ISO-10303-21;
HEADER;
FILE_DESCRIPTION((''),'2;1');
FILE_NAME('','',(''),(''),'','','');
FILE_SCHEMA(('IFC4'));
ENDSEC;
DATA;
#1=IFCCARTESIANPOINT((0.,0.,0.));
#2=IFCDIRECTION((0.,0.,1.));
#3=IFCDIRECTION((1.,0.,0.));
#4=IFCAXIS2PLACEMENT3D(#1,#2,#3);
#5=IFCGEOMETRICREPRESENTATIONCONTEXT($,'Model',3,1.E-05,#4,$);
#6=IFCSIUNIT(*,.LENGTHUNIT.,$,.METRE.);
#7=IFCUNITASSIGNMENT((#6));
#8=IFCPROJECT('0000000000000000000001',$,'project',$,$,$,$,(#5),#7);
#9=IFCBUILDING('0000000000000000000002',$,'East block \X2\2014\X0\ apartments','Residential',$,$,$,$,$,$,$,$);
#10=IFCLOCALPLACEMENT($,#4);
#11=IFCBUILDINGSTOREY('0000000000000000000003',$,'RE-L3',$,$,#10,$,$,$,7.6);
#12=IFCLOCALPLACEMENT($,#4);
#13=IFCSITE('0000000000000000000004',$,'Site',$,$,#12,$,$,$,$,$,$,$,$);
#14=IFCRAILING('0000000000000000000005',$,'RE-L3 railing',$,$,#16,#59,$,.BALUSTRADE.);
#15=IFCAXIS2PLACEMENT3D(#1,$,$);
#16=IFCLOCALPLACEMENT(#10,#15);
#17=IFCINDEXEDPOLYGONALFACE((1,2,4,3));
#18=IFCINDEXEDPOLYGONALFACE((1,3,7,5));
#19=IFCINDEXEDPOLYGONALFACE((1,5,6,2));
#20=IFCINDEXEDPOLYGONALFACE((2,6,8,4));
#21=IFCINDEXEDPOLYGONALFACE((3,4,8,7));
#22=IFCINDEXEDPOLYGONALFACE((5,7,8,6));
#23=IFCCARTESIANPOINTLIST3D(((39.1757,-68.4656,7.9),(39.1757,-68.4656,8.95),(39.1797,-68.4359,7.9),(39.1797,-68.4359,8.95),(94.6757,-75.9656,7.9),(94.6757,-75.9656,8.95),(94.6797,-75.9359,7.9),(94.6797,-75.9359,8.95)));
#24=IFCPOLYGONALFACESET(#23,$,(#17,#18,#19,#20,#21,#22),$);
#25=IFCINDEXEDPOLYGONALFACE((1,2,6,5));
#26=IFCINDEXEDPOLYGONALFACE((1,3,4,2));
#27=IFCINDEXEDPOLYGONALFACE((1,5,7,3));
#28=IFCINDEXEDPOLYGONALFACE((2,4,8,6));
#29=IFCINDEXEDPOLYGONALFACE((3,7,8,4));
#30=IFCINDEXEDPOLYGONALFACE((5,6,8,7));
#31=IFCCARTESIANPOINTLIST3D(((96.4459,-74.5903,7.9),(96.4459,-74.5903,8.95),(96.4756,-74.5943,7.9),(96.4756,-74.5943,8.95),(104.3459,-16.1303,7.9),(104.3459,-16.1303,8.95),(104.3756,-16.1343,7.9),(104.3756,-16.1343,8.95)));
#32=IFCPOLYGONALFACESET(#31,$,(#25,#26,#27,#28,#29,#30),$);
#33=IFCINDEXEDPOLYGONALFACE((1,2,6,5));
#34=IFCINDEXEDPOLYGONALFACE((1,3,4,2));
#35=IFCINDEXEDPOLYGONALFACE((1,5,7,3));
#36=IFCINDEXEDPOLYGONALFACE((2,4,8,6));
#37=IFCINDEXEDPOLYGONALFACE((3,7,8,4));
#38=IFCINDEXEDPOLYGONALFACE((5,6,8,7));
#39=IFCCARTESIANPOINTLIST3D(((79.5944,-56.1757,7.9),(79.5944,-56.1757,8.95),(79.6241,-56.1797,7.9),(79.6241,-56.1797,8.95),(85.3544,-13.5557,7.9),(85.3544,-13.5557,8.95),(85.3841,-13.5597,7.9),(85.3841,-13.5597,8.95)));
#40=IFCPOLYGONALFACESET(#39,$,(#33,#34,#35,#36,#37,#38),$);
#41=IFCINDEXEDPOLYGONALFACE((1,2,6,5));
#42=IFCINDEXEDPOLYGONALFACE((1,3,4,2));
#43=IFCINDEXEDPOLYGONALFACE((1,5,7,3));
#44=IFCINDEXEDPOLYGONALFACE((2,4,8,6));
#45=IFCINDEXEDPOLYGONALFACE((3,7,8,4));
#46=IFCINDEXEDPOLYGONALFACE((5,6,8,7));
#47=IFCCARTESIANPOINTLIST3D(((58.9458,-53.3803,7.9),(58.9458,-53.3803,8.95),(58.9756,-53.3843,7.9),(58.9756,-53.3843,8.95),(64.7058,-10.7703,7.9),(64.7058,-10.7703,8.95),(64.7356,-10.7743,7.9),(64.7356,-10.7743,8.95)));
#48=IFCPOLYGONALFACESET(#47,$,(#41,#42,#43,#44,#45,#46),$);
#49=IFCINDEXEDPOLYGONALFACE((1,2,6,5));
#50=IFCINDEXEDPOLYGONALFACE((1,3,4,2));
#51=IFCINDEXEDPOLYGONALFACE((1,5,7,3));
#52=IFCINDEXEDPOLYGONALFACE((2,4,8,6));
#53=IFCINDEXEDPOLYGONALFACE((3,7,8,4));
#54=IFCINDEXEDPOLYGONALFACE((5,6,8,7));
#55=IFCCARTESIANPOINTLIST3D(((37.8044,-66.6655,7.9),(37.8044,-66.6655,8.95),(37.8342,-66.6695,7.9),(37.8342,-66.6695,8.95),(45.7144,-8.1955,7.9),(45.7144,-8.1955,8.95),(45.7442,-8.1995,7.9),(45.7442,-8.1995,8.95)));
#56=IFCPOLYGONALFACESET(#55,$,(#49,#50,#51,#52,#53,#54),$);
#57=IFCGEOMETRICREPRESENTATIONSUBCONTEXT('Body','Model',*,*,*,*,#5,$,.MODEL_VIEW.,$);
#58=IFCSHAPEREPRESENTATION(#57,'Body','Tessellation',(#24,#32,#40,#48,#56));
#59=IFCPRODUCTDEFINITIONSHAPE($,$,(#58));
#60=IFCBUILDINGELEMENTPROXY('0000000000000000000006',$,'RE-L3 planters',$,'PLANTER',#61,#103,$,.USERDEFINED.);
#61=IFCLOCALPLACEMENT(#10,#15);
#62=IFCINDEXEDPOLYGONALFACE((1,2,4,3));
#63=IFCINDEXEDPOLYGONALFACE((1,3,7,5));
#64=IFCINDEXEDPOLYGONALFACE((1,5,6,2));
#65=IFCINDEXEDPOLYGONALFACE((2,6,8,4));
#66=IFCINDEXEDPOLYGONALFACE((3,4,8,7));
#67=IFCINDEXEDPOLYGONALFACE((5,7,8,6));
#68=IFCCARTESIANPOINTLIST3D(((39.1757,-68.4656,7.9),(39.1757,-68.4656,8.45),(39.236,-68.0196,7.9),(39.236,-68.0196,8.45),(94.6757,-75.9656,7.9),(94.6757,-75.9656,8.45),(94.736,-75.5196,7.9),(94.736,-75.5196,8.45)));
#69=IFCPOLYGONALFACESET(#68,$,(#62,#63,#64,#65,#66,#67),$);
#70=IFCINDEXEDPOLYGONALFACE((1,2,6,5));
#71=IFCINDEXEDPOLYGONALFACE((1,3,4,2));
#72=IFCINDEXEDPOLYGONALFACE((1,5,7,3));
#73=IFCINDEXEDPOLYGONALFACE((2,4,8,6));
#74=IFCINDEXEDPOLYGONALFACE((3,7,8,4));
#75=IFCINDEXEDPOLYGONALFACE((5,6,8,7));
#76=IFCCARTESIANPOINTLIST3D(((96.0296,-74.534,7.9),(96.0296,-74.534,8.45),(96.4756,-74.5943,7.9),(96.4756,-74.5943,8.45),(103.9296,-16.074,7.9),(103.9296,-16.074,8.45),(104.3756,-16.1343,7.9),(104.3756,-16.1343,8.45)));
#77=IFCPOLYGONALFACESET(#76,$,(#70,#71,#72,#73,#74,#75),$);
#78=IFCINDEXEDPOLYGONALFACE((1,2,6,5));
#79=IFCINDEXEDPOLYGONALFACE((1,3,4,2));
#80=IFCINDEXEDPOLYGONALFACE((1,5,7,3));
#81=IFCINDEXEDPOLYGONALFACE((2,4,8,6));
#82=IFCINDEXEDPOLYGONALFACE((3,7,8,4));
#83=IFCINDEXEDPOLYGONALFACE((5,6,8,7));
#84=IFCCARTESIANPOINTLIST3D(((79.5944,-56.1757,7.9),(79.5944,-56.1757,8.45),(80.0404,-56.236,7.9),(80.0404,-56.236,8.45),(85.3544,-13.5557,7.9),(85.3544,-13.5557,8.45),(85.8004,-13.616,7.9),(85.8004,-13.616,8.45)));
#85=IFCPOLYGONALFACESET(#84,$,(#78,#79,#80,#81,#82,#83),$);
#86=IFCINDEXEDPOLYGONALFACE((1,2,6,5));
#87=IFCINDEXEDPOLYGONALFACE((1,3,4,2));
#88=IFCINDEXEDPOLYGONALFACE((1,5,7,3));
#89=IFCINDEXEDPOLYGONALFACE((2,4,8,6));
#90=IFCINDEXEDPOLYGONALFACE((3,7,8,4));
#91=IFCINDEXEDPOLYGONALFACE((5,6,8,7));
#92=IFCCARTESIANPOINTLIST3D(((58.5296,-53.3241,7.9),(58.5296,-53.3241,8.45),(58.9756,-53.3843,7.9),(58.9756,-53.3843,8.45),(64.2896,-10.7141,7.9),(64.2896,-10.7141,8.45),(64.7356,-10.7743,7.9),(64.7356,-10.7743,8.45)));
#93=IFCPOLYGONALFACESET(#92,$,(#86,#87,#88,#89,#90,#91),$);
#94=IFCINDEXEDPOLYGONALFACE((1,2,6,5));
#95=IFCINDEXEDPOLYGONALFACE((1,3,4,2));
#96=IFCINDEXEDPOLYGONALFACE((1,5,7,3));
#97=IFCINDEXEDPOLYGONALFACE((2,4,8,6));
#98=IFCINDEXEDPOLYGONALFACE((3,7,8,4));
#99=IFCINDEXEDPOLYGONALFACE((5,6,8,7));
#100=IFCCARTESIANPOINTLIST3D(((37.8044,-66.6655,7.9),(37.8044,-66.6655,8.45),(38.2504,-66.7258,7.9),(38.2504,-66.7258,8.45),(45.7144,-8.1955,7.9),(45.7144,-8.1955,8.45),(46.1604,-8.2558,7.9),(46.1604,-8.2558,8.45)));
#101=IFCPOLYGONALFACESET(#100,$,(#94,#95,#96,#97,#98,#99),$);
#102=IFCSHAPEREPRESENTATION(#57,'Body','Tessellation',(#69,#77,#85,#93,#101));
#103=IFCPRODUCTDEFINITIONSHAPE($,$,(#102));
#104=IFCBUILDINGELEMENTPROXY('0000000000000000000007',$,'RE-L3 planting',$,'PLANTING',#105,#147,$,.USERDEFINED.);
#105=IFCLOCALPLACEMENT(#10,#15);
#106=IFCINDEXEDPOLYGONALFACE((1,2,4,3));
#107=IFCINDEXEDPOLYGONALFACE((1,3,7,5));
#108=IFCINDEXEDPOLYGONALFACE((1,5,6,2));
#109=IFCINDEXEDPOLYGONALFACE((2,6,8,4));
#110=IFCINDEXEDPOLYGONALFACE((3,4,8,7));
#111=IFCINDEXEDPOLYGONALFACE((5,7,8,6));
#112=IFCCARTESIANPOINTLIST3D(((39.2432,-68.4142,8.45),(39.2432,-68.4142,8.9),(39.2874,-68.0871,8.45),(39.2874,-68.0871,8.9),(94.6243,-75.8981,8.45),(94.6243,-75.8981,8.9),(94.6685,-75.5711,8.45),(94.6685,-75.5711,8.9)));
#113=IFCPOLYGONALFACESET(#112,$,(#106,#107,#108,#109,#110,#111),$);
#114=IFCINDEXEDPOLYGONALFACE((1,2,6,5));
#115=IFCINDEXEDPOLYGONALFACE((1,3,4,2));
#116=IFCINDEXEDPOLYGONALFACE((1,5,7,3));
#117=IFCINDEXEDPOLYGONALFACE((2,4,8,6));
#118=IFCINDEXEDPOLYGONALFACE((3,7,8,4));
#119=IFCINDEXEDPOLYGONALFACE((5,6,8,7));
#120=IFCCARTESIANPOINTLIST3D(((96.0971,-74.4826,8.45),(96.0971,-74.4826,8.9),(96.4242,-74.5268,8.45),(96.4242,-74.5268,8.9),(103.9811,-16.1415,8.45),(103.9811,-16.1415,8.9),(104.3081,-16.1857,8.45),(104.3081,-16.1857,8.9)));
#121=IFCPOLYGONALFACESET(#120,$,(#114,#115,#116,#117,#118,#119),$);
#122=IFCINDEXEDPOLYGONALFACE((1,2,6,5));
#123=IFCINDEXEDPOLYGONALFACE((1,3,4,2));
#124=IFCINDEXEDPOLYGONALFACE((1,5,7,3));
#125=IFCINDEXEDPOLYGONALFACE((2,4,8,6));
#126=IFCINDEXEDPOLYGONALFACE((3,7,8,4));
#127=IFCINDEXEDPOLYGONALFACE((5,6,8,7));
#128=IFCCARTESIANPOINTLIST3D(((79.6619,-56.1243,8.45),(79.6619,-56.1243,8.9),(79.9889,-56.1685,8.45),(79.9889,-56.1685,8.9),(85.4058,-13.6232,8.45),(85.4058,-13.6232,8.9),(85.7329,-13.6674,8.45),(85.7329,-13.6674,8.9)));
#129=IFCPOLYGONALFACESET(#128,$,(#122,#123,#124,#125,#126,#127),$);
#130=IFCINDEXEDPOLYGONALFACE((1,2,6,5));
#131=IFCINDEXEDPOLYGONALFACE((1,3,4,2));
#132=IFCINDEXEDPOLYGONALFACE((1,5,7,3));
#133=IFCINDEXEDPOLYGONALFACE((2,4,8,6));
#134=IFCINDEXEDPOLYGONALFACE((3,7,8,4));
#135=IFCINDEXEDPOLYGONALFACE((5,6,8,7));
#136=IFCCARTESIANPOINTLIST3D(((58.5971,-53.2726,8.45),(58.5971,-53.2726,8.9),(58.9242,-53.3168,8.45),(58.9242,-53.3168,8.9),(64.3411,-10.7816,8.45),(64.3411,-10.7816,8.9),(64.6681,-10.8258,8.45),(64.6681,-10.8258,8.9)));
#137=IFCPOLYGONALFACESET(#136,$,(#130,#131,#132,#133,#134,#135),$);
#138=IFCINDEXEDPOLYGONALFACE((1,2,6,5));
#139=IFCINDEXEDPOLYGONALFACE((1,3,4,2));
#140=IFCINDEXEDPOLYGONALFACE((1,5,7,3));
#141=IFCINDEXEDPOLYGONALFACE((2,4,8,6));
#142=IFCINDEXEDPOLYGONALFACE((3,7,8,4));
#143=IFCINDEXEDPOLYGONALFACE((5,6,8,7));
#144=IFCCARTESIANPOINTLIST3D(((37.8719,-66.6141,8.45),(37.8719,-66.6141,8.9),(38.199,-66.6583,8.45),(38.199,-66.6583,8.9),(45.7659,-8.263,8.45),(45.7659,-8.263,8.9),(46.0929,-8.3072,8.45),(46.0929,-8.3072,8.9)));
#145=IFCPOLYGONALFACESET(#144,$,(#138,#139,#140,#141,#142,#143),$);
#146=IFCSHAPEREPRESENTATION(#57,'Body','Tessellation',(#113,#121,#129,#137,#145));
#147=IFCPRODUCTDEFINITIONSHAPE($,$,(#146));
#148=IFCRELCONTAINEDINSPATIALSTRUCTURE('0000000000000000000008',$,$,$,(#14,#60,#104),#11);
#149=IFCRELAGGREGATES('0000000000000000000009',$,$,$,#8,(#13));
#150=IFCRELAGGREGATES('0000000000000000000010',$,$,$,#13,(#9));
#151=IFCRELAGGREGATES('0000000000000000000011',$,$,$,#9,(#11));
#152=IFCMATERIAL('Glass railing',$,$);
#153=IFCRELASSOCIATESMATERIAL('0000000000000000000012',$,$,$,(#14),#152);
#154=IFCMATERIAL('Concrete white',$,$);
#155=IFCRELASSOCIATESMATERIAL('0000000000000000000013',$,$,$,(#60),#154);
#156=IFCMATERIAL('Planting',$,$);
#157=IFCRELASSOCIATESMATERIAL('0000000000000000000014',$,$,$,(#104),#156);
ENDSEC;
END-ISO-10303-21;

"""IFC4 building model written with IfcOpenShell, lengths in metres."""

from ifc_helpers import new_model, si_unit, frame, origin_with_axes, place, context, subcontext, project, spatial, polyline, outline, extrude, material, element, save


model = new_model("IFC4")

# Units and contexts
model_context = context("Model", 3, precision=1e-05, world=origin_with_axes())
body_context = subcontext(model_context, "Body", "Model", "MODEL_VIEW")
ifc_project = project(units=[si_unit("LENGTHUNIT", "METRE")], contexts=[model_context])

# Site, building, storey
site_placement = place(None, origin_with_axes())
site = spatial("IfcSite", under=ifc_project, at=site_placement, Name="Site")
building = spatial("IfcBuilding", under=site, Name="East block — apartments", Description="Residential")
storey_placement = place(None, origin_with_axes())
storey = spatial("IfcBuildingStorey", under=building, at=storey_placement, Name="RE-L3", Elevation=7.6)

# Railing
ifc_material_1 = material(Name="Glass railing")
railing_placement = place(storey_placement, origin_with_axes())
element("IfcRailing", 1, at=railing_placement, inside=storey, material=ifc_material_1, Name="RE-L3 railing", PredefinedType="BALUSTRADE", context=body_context, shape_type="SweptSolid", body=[
    extrude(outline(polyline([(39.1757, -68.4656), (94.6757, -75.9656), (94.6797, -75.9359), (39.1797, -68.4359), (39.1757, -68.4656)])), frame((0.0, 0.0, 7.9), z_axis=(0.0, 0.0, 1.0), x_axis=(1.0, 0.0, 0.0)), (0.0, 0.0, 1.0), 1.05),
    extrude(outline(polyline([(96.4756, -74.5943), (104.3756, -16.1343), (104.3459, -16.1303), (96.4459, -74.5903), (96.4756, -74.5943)])), frame((0.0, 0.0, 7.9), z_axis=(0.0, 0.0, 1.0), x_axis=(1.0, 0.0, 0.0)), (0.0, 0.0, 1.0), 1.05),
    extrude(outline(polyline([(85.3544, -13.5557), (79.5944, -56.1757), (79.6241, -56.1797), (85.3841, -13.5597), (85.3544, -13.5557)])), frame((0.0, 0.0, 7.9), z_axis=(0.0, 0.0, 1.0), x_axis=(1.0, 0.0, 0.0)), (0.0, 0.0, 1.0), 1.05),
    extrude(outline(polyline([(58.9756, -53.3843), (64.7356, -10.7743), (64.7058, -10.7703), (58.9458, -53.3803), (58.9756, -53.3843)])), frame((0.0, 0.0, 7.9), z_axis=(0.0, 0.0, 1.0), x_axis=(1.0, 0.0, 0.0)), (0.0, 0.0, 1.0), 1.05),
    extrude(outline(polyline([(45.7144, -8.1955), (37.8044, -66.6655), (37.8342, -66.6695), (45.7442, -8.1995), (45.7144, -8.1955)])), frame((0.0, 0.0, 7.9), z_axis=(0.0, 0.0, 1.0), x_axis=(1.0, 0.0, 0.0)), (0.0, 0.0, 1.0), 1.05),
])

# Building element proxies
ifc_material_2 = material(Name="Concrete white")
proxy_1_placement = place(storey_placement, origin_with_axes())
element("IfcBuildingElementProxy", 2, at=proxy_1_placement, inside=storey, material=ifc_material_2, Name="RE-L3 planters", ObjectType="PLANTER", PredefinedType="USERDEFINED", context=body_context, shape_type="SweptSolid", body=[
    extrude(outline(polyline([(39.1757, -68.4656), (94.6757, -75.9656), (94.736, -75.5196), (39.236, -68.0196), (39.1757, -68.4656)])), frame((0.0, 0.0, 7.9), z_axis=(0.0, 0.0, 1.0), x_axis=(1.0, 0.0, 0.0)), (0.0, 0.0, 1.0), 0.55),
    extrude(outline(polyline([(96.4756, -74.5943), (104.3756, -16.1343), (103.9296, -16.074), (96.0296, -74.534), (96.4756, -74.5943)])), frame((0.0, 0.0, 7.9), z_axis=(0.0, 0.0, 1.0), x_axis=(1.0, 0.0, 0.0)), (0.0, 0.0, 1.0), 0.55),
    extrude(outline(polyline([(85.3544, -13.5557), (79.5944, -56.1757), (80.0404, -56.236), (85.8004, -13.616), (85.3544, -13.5557)])), frame((0.0, 0.0, 7.9), z_axis=(0.0, 0.0, 1.0), x_axis=(1.0, 0.0, 0.0)), (0.0, 0.0, 1.0), 0.55),
    extrude(outline(polyline([(58.9756, -53.3843), (64.7356, -10.7743), (64.2896, -10.7141), (58.5296, -53.3241), (58.9756, -53.3843)])), frame((0.0, 0.0, 7.9), z_axis=(0.0, 0.0, 1.0), x_axis=(1.0, 0.0, 0.0)), (0.0, 0.0, 1.0), 0.55),
    extrude(outline(polyline([(45.7144, -8.1955), (37.8044, -66.6655), (38.2504, -66.7258), (46.1604, -8.2558), (45.7144, -8.1955)])), frame((0.0, 0.0, 7.9), z_axis=(0.0, 0.0, 1.0), x_axis=(1.0, 0.0, 0.0)), (0.0, 0.0, 1.0), 0.55),
])
ifc_material_3 = material(Name="Planting")
proxy_2_placement = place(storey_placement, origin_with_axes())
element("IfcBuildingElementProxy", 3, at=proxy_2_placement, inside=storey, material=ifc_material_3, Name="RE-L3 planting", ObjectType="PLANTING", PredefinedType="USERDEFINED", context=body_context, shape_type="SweptSolid", body=[
    extrude(outline(polyline([(39.2432, -68.4142), (94.6243, -75.8981), (94.6685, -75.5711), (39.2874, -68.0871), (39.2432, -68.4142)])), frame((0.0, 0.0, 8.45), z_axis=(0.0, 0.0, 1.0), x_axis=(1.0, 0.0, 0.0)), (0.0, 0.0, 1.0), 0.45),
    extrude(outline(polyline([(96.4242, -74.5268), (104.3081, -16.1857), (103.9811, -16.1415), (96.0971, -74.4826), (96.4242, -74.5268)])), frame((0.0, 0.0, 8.45), z_axis=(0.0, 0.0, 1.0), x_axis=(1.0, 0.0, 0.0)), (0.0, 0.0, 1.0), 0.45),
    extrude(outline(polyline([(85.4058, -13.6232), (79.6619, -56.1243), (79.9889, -56.1685), (85.7329, -13.6674), (85.4058, -13.6232)])), frame((0.0, 0.0, 8.45), z_axis=(0.0, 0.0, 1.0), x_axis=(1.0, 0.0, 0.0)), (0.0, 0.0, 1.0), 0.45),
    extrude(outline(polyline([(58.9242, -53.3168), (64.6681, -10.8258), (64.3411, -10.7816), (58.5971, -53.2726), (58.9242, -53.3168)])), frame((0.0, 0.0, 8.45), z_axis=(0.0, 0.0, 1.0), x_axis=(1.0, 0.0, 0.0)), (0.0, 0.0, 1.0), 0.45),
    extrude(outline(polyline([(45.7659, -8.263), (37.8719, -66.6141), (38.199, -66.6583), (46.0929, -8.3072), (45.7659, -8.263)])), frame((0.0, 0.0, 8.45), z_axis=(0.0, 0.0, 1.0), x_axis=(1.0, 0.0, 0.0)), (0.0, 0.0, 1.0), 0.45),
])

save(model, "model.ifc")
